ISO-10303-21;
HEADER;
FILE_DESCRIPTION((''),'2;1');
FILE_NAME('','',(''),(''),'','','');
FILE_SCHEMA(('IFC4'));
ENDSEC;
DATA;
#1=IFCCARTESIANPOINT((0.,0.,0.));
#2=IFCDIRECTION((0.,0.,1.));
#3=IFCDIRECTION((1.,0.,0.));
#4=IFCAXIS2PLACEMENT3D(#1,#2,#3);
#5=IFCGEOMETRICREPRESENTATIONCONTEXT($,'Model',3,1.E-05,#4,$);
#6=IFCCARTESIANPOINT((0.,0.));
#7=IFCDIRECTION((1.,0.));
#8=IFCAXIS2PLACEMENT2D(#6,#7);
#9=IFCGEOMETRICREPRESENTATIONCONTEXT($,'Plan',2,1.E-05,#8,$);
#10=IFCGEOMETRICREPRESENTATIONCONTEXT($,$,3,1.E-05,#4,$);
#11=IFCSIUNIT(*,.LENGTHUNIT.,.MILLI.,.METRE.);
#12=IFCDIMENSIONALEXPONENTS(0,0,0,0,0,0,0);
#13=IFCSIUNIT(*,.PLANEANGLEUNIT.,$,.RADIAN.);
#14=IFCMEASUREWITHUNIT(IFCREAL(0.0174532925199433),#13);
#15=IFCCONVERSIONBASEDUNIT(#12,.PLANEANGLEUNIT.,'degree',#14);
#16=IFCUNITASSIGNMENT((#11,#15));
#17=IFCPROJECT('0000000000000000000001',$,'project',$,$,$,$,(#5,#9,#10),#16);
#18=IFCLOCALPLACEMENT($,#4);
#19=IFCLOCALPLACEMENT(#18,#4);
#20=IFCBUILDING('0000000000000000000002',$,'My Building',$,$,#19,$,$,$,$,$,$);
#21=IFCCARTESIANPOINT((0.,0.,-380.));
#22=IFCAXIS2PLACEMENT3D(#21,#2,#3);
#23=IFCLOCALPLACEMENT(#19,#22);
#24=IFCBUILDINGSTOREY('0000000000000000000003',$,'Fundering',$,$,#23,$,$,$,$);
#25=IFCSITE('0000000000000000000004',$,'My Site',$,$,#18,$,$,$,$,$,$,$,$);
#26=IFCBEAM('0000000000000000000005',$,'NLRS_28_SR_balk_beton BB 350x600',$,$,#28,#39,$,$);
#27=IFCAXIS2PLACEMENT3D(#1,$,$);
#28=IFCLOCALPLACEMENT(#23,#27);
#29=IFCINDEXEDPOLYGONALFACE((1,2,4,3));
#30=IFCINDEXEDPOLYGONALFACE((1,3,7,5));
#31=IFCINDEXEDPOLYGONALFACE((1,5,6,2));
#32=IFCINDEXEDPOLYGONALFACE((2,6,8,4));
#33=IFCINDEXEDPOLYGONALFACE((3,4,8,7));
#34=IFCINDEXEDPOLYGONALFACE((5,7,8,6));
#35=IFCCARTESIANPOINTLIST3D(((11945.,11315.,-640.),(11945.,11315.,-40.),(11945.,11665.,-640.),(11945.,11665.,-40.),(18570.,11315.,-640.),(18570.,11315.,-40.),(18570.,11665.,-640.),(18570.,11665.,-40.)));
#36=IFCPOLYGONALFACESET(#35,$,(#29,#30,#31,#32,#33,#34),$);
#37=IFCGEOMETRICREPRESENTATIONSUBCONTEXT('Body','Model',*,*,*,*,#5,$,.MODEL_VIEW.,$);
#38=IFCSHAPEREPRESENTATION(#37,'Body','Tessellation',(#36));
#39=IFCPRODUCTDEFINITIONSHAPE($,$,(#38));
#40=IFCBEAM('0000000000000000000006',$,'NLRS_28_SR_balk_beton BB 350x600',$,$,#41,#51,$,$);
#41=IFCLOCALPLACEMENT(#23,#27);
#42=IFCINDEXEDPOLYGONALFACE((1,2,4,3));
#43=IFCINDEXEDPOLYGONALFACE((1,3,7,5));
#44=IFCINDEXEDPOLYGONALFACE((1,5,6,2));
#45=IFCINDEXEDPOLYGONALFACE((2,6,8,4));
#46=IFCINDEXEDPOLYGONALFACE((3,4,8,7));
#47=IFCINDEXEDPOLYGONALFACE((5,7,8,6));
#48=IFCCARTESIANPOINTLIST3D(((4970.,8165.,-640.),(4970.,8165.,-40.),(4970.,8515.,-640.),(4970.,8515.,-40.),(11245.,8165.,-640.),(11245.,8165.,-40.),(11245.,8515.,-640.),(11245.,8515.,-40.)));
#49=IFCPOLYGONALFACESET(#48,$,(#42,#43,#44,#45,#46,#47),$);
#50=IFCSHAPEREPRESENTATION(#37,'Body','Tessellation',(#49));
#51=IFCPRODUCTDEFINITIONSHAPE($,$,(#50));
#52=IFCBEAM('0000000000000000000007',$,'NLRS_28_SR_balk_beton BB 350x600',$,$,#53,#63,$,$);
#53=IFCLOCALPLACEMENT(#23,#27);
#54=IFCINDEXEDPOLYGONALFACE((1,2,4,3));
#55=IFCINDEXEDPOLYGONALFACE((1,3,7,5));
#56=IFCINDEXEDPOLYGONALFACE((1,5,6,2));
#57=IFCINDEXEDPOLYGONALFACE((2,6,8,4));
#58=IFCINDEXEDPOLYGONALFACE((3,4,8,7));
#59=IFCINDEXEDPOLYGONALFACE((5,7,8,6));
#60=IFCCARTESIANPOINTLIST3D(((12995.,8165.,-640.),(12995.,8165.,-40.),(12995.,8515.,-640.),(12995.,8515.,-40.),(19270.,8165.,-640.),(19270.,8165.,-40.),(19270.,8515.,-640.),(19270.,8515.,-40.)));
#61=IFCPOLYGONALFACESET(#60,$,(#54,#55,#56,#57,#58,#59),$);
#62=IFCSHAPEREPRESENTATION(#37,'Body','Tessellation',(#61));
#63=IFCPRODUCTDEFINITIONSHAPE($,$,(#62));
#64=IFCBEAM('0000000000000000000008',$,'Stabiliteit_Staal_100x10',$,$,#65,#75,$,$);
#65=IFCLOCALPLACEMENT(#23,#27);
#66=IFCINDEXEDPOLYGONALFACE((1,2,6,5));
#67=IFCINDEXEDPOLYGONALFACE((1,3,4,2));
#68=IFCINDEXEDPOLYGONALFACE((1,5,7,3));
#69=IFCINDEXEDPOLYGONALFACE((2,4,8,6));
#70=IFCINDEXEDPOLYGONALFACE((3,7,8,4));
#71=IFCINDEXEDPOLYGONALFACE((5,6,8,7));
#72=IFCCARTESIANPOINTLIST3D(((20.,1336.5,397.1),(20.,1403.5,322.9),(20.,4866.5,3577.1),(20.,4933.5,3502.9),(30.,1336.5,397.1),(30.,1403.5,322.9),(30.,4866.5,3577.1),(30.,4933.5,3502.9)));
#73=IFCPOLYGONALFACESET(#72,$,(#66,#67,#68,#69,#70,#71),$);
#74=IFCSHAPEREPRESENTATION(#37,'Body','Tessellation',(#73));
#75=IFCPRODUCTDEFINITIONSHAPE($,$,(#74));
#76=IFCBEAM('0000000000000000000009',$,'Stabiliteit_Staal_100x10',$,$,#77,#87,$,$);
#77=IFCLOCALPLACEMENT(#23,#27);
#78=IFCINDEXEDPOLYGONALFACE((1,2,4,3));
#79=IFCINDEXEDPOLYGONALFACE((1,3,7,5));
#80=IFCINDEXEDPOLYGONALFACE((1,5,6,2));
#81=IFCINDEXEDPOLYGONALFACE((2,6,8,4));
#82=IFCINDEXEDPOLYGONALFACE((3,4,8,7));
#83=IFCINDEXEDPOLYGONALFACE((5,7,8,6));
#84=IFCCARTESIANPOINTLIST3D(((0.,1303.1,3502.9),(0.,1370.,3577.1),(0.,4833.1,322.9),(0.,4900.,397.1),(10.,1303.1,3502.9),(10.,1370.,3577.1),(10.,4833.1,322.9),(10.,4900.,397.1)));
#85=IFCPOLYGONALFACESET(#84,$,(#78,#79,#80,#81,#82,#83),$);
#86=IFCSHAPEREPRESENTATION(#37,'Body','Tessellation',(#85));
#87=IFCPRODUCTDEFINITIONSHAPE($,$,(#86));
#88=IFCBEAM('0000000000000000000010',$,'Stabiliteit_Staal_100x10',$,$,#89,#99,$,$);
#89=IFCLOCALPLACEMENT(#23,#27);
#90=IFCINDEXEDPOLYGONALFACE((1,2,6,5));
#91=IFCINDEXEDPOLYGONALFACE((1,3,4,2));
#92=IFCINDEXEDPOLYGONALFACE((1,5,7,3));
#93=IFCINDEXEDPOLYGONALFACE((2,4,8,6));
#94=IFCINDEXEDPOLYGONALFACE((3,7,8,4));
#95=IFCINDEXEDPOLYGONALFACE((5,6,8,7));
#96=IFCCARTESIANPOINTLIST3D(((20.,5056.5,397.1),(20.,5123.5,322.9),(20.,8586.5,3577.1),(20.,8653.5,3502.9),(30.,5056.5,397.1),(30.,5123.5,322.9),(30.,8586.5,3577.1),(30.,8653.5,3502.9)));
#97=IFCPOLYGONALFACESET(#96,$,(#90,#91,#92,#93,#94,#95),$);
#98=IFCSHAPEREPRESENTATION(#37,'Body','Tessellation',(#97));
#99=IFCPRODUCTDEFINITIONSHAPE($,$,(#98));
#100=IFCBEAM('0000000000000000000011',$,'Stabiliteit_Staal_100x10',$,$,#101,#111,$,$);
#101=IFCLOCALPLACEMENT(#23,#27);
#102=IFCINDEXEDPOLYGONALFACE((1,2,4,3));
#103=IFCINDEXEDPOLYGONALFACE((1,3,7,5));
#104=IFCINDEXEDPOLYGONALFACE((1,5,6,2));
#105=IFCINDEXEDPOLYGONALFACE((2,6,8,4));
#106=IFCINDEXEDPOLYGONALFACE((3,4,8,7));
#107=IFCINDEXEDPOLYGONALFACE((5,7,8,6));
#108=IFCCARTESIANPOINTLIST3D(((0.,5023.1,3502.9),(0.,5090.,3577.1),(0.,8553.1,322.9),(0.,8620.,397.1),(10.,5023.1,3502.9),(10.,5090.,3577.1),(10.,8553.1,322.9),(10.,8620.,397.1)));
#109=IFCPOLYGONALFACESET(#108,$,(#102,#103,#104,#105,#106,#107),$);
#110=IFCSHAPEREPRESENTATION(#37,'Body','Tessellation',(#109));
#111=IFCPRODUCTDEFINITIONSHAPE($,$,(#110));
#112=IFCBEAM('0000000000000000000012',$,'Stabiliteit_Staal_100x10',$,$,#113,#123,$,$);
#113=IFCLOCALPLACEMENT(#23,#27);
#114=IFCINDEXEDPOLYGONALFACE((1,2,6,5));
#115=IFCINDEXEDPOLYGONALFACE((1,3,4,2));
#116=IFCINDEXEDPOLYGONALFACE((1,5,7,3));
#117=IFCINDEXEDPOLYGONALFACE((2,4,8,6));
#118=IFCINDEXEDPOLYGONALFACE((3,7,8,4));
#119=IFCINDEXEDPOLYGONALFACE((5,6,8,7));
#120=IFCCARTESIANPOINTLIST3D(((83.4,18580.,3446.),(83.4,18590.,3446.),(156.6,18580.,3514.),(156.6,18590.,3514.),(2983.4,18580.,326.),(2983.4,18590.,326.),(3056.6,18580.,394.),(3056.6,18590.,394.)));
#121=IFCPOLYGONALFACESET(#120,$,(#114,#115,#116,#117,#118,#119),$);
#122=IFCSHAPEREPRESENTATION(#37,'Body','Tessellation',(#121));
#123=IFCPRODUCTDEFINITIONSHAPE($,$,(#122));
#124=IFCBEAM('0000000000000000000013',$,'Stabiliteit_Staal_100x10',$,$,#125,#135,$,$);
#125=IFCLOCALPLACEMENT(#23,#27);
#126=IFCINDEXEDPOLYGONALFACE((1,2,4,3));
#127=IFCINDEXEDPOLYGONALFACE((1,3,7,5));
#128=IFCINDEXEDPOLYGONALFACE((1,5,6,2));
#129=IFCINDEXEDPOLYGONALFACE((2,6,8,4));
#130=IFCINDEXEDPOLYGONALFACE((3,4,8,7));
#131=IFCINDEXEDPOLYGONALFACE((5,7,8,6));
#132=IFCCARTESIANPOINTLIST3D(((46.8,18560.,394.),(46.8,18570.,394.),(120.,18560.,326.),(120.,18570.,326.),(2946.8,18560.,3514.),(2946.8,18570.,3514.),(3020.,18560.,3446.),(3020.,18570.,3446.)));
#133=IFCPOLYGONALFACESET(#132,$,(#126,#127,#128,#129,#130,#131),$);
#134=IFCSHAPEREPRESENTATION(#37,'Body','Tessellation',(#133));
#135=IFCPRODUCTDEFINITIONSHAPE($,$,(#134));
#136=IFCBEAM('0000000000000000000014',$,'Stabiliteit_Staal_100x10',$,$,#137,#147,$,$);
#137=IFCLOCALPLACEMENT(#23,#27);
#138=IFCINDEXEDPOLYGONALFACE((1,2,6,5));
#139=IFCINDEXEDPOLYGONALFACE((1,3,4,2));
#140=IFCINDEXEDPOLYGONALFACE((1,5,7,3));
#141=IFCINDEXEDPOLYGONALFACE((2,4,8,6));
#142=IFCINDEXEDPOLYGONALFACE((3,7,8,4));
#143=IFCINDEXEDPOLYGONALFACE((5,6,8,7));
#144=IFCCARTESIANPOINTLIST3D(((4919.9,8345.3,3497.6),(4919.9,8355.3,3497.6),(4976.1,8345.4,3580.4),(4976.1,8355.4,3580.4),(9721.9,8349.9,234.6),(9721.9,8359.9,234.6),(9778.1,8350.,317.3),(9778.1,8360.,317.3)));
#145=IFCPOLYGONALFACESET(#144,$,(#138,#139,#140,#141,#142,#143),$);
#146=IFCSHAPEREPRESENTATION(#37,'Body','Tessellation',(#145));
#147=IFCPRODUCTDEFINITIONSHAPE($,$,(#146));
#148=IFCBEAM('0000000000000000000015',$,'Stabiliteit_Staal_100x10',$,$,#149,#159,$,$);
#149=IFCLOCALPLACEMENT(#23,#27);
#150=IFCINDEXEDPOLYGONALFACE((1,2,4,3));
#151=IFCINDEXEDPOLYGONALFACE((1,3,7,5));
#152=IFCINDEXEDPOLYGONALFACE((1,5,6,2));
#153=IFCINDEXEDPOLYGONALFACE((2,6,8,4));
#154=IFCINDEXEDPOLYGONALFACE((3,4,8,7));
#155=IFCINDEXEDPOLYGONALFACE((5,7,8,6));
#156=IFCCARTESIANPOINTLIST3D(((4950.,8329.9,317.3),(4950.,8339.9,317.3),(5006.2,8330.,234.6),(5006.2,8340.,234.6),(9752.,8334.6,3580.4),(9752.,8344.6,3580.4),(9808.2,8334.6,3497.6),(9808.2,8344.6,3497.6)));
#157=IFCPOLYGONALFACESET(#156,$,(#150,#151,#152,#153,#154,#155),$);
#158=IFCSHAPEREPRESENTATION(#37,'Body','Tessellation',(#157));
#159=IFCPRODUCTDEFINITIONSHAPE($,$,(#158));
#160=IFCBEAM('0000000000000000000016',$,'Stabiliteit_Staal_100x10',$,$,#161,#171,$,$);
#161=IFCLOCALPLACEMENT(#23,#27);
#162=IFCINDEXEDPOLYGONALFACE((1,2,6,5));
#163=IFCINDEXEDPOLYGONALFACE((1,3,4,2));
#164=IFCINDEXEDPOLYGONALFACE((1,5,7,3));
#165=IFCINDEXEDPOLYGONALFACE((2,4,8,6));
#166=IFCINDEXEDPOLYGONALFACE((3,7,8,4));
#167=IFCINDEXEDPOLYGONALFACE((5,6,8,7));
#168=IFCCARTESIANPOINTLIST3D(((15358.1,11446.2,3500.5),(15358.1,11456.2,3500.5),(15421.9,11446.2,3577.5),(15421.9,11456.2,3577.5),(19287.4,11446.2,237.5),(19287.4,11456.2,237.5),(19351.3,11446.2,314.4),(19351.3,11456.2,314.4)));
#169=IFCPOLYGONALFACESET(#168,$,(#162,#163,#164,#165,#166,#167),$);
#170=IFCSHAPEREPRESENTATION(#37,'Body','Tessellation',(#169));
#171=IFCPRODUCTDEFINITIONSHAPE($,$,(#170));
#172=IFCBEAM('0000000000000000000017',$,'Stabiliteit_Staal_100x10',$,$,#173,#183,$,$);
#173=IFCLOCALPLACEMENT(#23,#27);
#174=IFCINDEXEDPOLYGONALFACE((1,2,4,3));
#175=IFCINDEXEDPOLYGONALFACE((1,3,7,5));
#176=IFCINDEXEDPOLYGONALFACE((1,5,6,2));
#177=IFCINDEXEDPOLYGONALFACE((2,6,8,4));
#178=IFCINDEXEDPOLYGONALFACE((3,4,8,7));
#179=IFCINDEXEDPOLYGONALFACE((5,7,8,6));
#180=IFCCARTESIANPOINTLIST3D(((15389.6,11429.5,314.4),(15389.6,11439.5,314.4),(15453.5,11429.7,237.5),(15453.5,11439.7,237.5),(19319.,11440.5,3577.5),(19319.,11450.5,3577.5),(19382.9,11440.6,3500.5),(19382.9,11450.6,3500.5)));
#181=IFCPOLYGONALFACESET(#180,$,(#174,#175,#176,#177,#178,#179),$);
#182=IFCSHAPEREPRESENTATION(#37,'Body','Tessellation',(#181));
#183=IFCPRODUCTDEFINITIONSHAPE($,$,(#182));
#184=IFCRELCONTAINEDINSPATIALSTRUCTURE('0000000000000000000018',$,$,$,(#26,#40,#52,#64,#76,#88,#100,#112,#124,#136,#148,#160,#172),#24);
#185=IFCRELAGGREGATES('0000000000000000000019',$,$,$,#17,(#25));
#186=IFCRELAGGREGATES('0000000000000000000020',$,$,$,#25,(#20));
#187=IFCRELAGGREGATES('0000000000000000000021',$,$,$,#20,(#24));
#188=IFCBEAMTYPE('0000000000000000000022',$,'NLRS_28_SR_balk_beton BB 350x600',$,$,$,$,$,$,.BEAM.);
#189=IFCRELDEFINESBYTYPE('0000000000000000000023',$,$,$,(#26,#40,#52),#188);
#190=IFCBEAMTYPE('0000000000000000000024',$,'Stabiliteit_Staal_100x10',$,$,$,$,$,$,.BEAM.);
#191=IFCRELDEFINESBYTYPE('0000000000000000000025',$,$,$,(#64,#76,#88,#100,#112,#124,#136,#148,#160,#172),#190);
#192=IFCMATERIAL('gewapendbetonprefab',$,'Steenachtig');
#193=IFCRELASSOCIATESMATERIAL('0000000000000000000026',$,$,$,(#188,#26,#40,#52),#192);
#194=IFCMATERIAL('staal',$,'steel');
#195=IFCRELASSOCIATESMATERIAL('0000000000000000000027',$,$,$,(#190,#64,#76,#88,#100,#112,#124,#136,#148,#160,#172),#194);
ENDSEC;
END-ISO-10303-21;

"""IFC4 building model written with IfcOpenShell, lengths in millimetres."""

from ifc_helpers import new_model, entity, si_unit, converted_unit, frame, origin_with_axes, origin_2d_with_axis, place, context, subcontext, project, spatial, rectangle, extrude, material, material_profile, profile_set, profile_usage, type_object, element, save


model = new_model("IFC4")

# Units and contexts
model_context = context("Model", 3, precision=1e-05, world=origin_with_axes())
plan_context = context("Plan", 2, precision=1e-05, world=origin_2d_with_axis())
context_of_model = context(None, 3, precision=1e-05, world=origin_with_axes())
body_context = subcontext(model_context, "Body", "Model", "MODEL_VIEW")
ifc_project = project(units=[si_unit("LENGTHUNIT", "METRE", prefix="MILLI"), converted_unit("PLANEANGLEUNIT", "degree", entity("IfcReal", 0.0174532925199433), si_unit("PLANEANGLEUNIT", "RADIAN"), dimensions=[0, 0, 0, 0, 0, 0, 0])], contexts=[model_context, plan_context, context_of_model])

# Site, building, storey
site_placement = place(None, origin_with_axes())
site = spatial("IfcSite", under=ifc_project, at=site_placement, Name="My Site")
building_placement = place(site_placement, origin_with_axes())
building = spatial("IfcBuilding", under=site, at=building_placement, Name="My Building")
storey_placement = place(building_placement, frame((0.0, 0.0, -380.0), z_axis=(0.0, 0.0, 1.0), x_axis=(1.0, 0.0, 0.0)))
storey = spatial("IfcBuildingStorey", under=building, at=storey_placement, Name="Fundering")

# Beams
ifc_material_1 = material(Name="gewapendbetonprefab", Category="Steenachtig")
ifc_material_profile_1 = material_profile(ifc_material_1, rectangle(XDim=350.0, YDim=600.0))
ifc_profile_set_1 = profile_set([ifc_material_profile_1], Name="NLRS_28_SR_balk_beton BB 350x600")
beam_type_1 = type_object("IfcBeamType", Name="NLRS_28_SR_balk_beton BB 350x600", PredefinedType="BEAM", material=ifc_profile_set_1)
ifc_profile_usage_1 = profile_usage(ifc_profile_set_1, cardinal=8)
beam_1_placement = place(storey_placement, frame((18570.0, 11490.0, -40.0), z_axis=(-1.0, 0.0, 0.0), x_axis=(0.0, -1.0, 0.0)))
element("IfcBeam", 1, at=beam_1_placement, inside=storey, type_object=beam_type_1, material=ifc_profile_usage_1, Name="NLRS_28_SR_balk_beton BB 350x600", context=body_context, shape_type="SweptSolid", body=[
    extrude(rectangle(XDim=350.0, YDim=600.0), frame((0.0, -300.0, 0.0), z_axis=(0.0, 0.0, 1.0), x_axis=(1.0, 0.0, 0.0)), (0.0, 0.0, 1.0), 6625.0),
])
ifc_profile_usage_2 = profile_usage(ifc_profile_set_1, cardinal=8)
beam_2_placement = place(storey_placement, frame((11245.0, 8340.0, -40.0), z_axis=(-1.0, 0.0, 0.0), x_axis=(0.0, -1.0, 0.0)))
element("IfcBeam", 2, at=beam_2_placement, inside=storey, type_object=beam_type_1, material=ifc_profile_usage_2, Name="NLRS_28_SR_balk_beton BB 350x600", context=body_context, shape_type="SweptSolid", body=[
    extrude(rectangle(XDim=350.0, YDim=600.0), frame((0.0, -300.0, 0.0), z_axis=(0.0, 0.0, 1.0), x_axis=(1.0, 0.0, 0.0)), (0.0, 0.0, 1.0), 6275.0),
])
ifc_profile_usage_3 = profile_usage(ifc_profile_set_1, cardinal=8)
beam_3_placement = place(storey_placement, frame((19270.0, 8340.0, -40.0), z_axis=(-1.0, 0.0, 0.0), x_axis=(0.0, -1.0, 0.0)))
element("IfcBeam", 3, at=beam_3_placement, inside=storey, type_object=beam_type_1, material=ifc_profile_usage_3, Name="NLRS_28_SR_balk_beton BB 350x600", context=body_context, shape_type="SweptSolid", body=[
    extrude(rectangle(XDim=350.0, YDim=600.0), frame((0.0, -300.0, 0.0), z_axis=(0.0, 0.0, 1.0), x_axis=(1.0, 0.0, 0.0)), (0.0, 0.0, 1.0), 6275.0),
])
ifc_material_2 = material(Name="staal", Category="steel")
ifc_material_profile_2 = material_profile(ifc_material_2, rectangle(XDim=10.0, YDim=100.0, kind="CURVE"))
ifc_profile_set_2 = profile_set([ifc_material_profile_2])
ifc_profile_usage_4 = profile_usage(ifc_profile_set_2, cardinal=5)
beam_type_2 = type_object("IfcBeamType", Name="Stabiliteit_Staal_100x10", PredefinedType="BEAM", material=ifc_profile_set_2)
beam_4_placement = place(storey_placement, frame((25.0, 1370.0, 360.0), z_axis=(0.0, 0.74298, 0.669313), x_axis=(-1.0, 0.0, 0.0)))
element("IfcBeam", 4, at=beam_4_placement, inside=storey, type_object=beam_type_2, material=ifc_profile_usage_4, Name="Stabiliteit_Staal_100x10", context=body_context, shape_type="SweptSolid", body=[
    extrude(rectangle(XDim=10.0, YDim=100.0, kind="CURVE"), origin_with_axes(), (0.0, 0.0, 1.0), 4751.1),
])
ifc_profile_usage_5 = profile_usage(ifc_profile_set_2, cardinal=5)
beam_5_placement = place(storey_placement, frame((5.0, 4866.5, 360.0), z_axis=(0.0, -0.74298, 0.669313), x_axis=(1.0, 0.0, 0.0)))
element("IfcBeam", 5, at=beam_5_placement, inside=storey, type_object=beam_type_2, material=ifc_profile_usage_5, Name="Stabiliteit_Staal_100x10", context=body_context, shape_type="SweptSolid", body=[
    extrude(rectangle(XDim=10.0, YDim=100.0, kind="CURVE"), origin_with_axes(), (0.0, 0.0, 1.0), 4751.1),
])
ifc_profile_usage_6 = profile_usage(ifc_profile_set_2, cardinal=5)
beam_6_placement = place(storey_placement, frame((25.0, 5090.0, 360.0), z_axis=(0.0, 0.74298, 0.669313), x_axis=(-1.0, 0.0, 0.0)))
element("IfcBeam", 6, at=beam_6_placement, inside=storey, type_object=beam_type_2, material=ifc_profile_usage_6, Name="Stabiliteit_Staal_100x10", context=body_context, shape_type="SweptSolid", body=[
    extrude(rectangle(XDim=10.0, YDim=100.0, kind="CURVE"), origin_with_axes(), (0.0, 0.0, 1.0), 4751.1),
])
ifc_profile_usage_7 = profile_usage(ifc_profile_set_2, cardinal=5)
beam_7_placement = place(storey_placement, frame((5.0, 8586.5, 360.0), z_axis=(0.0, -0.74298, 0.669313), x_axis=(1.0, 0.0, 0.0)))
element("IfcBeam", 7, at=beam_7_placement, inside=storey, type_object=beam_type_2, material=ifc_profile_usage_7, Name="Stabiliteit_Staal_100x10", context=body_context, shape_type="SweptSolid", body=[
    extrude(rectangle(XDim=10.0, YDim=100.0, kind="CURVE"), origin_with_axes(), (0.0, 0.0, 1.0), 4751.1),
])
ifc_profile_usage_8 = profile_usage(ifc_profile_set_2, cardinal=5)
beam_8_placement = place(storey_placement, frame((3020.0, 18585.0, 360.0), z_axis=(-0.680811, 0.0, 0.732459), x_axis=(0.0, -1.0, 0.0)))
element("IfcBeam", 8, at=beam_8_placement, inside=storey, type_object=beam_type_2, material=ifc_profile_usage_8, Name="Stabiliteit_Staal_100x10", context=body_context, shape_type="SweptSolid", body=[
    extrude(rectangle(XDim=10.0, YDim=100.0, kind="CURVE"), origin_with_axes(), (0.0, 0.0, 1.0), 4259.6),
])
ifc_profile_usage_9 = profile_usage(ifc_profile_set_2, cardinal=5)
beam_9_placement = place(storey_placement, frame((83.4, 18565.0, 360.0), z_axis=(0.680811, 0.0, 0.732459), x_axis=(0.0, 1.0, 0.0)))
element("IfcBeam", 9, at=beam_9_placement, inside=storey, type_object=beam_type_2, material=ifc_profile_usage_9, Name="Stabiliteit_Staal_100x10", context=body_context, shape_type="SweptSolid", body=[
    extrude(rectangle(XDim=10.0, YDim=100.0, kind="CURVE"), origin_with_axes(), (0.0, 0.0, 1.0), 4259.6),
])
ifc_profile_usage_10 = profile_usage(ifc_profile_set_2, cardinal=5)
beam_10_placement = place(storey_placement, frame((9750.0, 8355.0, 276.0), z_axis=(-0.827111, -0.000798, 0.562038), x_axis=(0.000965, -1.0, 0.0)))
element("IfcBeam", 10, at=beam_10_placement, inside=storey, type_object=beam_type_2, material=ifc_profile_usage_10, Name="Stabiliteit_Staal_100x10", context=body_context, shape_type="SweptSolid", body=[
    extrude(rectangle(XDim=10.0, YDim=100.0, kind="CURVE"), origin_with_axes(), (0.0, 0.0, 1.0), 5805.7),
])
ifc_profile_usage_11 = profile_usage(ifc_profile_set_2, cardinal=5)
beam_11_placement = place(storey_placement, frame((4978.1, 8335.0, 276.0), z_axis=(0.827111, 0.000798, 0.562038), x_axis=(-0.000965, 1.0, 0.0)))
element("IfcBeam", 11, at=beam_11_placement, inside=storey, type_object=beam_type_2, material=ifc_profile_usage_11, Name="Stabiliteit_Staal_100x10", context=body_context, shape_type="SweptSolid", body=[
    extrude(rectangle(XDim=10.0, YDim=100.0, kind="CURVE"), origin_with_axes(), (0.0, 0.0, 1.0), 5805.7),
])
ifc_profile_usage_12 = profile_usage(ifc_profile_set_2, cardinal=5)
beam_12_placement = place(storey_placement, frame((19319.4, 11451.2, 276.0), z_axis=(-0.769322, 0.0, 0.638862), x_axis=(0.0, -1.0, 0.0)))
element("IfcBeam", 12, at=beam_12_placement, inside=storey, type_object=beam_type_2, material=ifc_profile_usage_12, Name="Stabiliteit_Staal_100x10", context=body_context, shape_type="SweptSolid", body=[
    extrude(rectangle(XDim=10.0, YDim=100.0, kind="CURVE"), origin_with_axes(), (0.0, 0.0, 1.0), 5107.6),
])
ifc_profile_usage_13 = profile_usage(ifc_profile_set_2, cardinal=5)
beam_13_placement = place(storey_placement, frame((15421.6, 11434.6, 276.0), z_axis=(0.76932, 0.002151, 0.63886), x_axis=(-0.002796, 0.999996, 0.0)))
element("IfcBeam", 13, at=beam_13_placement, inside=storey, type_object=beam_type_2, material=ifc_profile_usage_13, Name="Stabiliteit_Staal_100x10", context=body_context, shape_type="SweptSolid", body=[
    extrude(rectangle(XDim=10.0, YDim=100.0, kind="CURVE"), origin_with_axes(), (0.0, 0.0, 1.0), 5107.6),
])

save(model, "model.ifc")
